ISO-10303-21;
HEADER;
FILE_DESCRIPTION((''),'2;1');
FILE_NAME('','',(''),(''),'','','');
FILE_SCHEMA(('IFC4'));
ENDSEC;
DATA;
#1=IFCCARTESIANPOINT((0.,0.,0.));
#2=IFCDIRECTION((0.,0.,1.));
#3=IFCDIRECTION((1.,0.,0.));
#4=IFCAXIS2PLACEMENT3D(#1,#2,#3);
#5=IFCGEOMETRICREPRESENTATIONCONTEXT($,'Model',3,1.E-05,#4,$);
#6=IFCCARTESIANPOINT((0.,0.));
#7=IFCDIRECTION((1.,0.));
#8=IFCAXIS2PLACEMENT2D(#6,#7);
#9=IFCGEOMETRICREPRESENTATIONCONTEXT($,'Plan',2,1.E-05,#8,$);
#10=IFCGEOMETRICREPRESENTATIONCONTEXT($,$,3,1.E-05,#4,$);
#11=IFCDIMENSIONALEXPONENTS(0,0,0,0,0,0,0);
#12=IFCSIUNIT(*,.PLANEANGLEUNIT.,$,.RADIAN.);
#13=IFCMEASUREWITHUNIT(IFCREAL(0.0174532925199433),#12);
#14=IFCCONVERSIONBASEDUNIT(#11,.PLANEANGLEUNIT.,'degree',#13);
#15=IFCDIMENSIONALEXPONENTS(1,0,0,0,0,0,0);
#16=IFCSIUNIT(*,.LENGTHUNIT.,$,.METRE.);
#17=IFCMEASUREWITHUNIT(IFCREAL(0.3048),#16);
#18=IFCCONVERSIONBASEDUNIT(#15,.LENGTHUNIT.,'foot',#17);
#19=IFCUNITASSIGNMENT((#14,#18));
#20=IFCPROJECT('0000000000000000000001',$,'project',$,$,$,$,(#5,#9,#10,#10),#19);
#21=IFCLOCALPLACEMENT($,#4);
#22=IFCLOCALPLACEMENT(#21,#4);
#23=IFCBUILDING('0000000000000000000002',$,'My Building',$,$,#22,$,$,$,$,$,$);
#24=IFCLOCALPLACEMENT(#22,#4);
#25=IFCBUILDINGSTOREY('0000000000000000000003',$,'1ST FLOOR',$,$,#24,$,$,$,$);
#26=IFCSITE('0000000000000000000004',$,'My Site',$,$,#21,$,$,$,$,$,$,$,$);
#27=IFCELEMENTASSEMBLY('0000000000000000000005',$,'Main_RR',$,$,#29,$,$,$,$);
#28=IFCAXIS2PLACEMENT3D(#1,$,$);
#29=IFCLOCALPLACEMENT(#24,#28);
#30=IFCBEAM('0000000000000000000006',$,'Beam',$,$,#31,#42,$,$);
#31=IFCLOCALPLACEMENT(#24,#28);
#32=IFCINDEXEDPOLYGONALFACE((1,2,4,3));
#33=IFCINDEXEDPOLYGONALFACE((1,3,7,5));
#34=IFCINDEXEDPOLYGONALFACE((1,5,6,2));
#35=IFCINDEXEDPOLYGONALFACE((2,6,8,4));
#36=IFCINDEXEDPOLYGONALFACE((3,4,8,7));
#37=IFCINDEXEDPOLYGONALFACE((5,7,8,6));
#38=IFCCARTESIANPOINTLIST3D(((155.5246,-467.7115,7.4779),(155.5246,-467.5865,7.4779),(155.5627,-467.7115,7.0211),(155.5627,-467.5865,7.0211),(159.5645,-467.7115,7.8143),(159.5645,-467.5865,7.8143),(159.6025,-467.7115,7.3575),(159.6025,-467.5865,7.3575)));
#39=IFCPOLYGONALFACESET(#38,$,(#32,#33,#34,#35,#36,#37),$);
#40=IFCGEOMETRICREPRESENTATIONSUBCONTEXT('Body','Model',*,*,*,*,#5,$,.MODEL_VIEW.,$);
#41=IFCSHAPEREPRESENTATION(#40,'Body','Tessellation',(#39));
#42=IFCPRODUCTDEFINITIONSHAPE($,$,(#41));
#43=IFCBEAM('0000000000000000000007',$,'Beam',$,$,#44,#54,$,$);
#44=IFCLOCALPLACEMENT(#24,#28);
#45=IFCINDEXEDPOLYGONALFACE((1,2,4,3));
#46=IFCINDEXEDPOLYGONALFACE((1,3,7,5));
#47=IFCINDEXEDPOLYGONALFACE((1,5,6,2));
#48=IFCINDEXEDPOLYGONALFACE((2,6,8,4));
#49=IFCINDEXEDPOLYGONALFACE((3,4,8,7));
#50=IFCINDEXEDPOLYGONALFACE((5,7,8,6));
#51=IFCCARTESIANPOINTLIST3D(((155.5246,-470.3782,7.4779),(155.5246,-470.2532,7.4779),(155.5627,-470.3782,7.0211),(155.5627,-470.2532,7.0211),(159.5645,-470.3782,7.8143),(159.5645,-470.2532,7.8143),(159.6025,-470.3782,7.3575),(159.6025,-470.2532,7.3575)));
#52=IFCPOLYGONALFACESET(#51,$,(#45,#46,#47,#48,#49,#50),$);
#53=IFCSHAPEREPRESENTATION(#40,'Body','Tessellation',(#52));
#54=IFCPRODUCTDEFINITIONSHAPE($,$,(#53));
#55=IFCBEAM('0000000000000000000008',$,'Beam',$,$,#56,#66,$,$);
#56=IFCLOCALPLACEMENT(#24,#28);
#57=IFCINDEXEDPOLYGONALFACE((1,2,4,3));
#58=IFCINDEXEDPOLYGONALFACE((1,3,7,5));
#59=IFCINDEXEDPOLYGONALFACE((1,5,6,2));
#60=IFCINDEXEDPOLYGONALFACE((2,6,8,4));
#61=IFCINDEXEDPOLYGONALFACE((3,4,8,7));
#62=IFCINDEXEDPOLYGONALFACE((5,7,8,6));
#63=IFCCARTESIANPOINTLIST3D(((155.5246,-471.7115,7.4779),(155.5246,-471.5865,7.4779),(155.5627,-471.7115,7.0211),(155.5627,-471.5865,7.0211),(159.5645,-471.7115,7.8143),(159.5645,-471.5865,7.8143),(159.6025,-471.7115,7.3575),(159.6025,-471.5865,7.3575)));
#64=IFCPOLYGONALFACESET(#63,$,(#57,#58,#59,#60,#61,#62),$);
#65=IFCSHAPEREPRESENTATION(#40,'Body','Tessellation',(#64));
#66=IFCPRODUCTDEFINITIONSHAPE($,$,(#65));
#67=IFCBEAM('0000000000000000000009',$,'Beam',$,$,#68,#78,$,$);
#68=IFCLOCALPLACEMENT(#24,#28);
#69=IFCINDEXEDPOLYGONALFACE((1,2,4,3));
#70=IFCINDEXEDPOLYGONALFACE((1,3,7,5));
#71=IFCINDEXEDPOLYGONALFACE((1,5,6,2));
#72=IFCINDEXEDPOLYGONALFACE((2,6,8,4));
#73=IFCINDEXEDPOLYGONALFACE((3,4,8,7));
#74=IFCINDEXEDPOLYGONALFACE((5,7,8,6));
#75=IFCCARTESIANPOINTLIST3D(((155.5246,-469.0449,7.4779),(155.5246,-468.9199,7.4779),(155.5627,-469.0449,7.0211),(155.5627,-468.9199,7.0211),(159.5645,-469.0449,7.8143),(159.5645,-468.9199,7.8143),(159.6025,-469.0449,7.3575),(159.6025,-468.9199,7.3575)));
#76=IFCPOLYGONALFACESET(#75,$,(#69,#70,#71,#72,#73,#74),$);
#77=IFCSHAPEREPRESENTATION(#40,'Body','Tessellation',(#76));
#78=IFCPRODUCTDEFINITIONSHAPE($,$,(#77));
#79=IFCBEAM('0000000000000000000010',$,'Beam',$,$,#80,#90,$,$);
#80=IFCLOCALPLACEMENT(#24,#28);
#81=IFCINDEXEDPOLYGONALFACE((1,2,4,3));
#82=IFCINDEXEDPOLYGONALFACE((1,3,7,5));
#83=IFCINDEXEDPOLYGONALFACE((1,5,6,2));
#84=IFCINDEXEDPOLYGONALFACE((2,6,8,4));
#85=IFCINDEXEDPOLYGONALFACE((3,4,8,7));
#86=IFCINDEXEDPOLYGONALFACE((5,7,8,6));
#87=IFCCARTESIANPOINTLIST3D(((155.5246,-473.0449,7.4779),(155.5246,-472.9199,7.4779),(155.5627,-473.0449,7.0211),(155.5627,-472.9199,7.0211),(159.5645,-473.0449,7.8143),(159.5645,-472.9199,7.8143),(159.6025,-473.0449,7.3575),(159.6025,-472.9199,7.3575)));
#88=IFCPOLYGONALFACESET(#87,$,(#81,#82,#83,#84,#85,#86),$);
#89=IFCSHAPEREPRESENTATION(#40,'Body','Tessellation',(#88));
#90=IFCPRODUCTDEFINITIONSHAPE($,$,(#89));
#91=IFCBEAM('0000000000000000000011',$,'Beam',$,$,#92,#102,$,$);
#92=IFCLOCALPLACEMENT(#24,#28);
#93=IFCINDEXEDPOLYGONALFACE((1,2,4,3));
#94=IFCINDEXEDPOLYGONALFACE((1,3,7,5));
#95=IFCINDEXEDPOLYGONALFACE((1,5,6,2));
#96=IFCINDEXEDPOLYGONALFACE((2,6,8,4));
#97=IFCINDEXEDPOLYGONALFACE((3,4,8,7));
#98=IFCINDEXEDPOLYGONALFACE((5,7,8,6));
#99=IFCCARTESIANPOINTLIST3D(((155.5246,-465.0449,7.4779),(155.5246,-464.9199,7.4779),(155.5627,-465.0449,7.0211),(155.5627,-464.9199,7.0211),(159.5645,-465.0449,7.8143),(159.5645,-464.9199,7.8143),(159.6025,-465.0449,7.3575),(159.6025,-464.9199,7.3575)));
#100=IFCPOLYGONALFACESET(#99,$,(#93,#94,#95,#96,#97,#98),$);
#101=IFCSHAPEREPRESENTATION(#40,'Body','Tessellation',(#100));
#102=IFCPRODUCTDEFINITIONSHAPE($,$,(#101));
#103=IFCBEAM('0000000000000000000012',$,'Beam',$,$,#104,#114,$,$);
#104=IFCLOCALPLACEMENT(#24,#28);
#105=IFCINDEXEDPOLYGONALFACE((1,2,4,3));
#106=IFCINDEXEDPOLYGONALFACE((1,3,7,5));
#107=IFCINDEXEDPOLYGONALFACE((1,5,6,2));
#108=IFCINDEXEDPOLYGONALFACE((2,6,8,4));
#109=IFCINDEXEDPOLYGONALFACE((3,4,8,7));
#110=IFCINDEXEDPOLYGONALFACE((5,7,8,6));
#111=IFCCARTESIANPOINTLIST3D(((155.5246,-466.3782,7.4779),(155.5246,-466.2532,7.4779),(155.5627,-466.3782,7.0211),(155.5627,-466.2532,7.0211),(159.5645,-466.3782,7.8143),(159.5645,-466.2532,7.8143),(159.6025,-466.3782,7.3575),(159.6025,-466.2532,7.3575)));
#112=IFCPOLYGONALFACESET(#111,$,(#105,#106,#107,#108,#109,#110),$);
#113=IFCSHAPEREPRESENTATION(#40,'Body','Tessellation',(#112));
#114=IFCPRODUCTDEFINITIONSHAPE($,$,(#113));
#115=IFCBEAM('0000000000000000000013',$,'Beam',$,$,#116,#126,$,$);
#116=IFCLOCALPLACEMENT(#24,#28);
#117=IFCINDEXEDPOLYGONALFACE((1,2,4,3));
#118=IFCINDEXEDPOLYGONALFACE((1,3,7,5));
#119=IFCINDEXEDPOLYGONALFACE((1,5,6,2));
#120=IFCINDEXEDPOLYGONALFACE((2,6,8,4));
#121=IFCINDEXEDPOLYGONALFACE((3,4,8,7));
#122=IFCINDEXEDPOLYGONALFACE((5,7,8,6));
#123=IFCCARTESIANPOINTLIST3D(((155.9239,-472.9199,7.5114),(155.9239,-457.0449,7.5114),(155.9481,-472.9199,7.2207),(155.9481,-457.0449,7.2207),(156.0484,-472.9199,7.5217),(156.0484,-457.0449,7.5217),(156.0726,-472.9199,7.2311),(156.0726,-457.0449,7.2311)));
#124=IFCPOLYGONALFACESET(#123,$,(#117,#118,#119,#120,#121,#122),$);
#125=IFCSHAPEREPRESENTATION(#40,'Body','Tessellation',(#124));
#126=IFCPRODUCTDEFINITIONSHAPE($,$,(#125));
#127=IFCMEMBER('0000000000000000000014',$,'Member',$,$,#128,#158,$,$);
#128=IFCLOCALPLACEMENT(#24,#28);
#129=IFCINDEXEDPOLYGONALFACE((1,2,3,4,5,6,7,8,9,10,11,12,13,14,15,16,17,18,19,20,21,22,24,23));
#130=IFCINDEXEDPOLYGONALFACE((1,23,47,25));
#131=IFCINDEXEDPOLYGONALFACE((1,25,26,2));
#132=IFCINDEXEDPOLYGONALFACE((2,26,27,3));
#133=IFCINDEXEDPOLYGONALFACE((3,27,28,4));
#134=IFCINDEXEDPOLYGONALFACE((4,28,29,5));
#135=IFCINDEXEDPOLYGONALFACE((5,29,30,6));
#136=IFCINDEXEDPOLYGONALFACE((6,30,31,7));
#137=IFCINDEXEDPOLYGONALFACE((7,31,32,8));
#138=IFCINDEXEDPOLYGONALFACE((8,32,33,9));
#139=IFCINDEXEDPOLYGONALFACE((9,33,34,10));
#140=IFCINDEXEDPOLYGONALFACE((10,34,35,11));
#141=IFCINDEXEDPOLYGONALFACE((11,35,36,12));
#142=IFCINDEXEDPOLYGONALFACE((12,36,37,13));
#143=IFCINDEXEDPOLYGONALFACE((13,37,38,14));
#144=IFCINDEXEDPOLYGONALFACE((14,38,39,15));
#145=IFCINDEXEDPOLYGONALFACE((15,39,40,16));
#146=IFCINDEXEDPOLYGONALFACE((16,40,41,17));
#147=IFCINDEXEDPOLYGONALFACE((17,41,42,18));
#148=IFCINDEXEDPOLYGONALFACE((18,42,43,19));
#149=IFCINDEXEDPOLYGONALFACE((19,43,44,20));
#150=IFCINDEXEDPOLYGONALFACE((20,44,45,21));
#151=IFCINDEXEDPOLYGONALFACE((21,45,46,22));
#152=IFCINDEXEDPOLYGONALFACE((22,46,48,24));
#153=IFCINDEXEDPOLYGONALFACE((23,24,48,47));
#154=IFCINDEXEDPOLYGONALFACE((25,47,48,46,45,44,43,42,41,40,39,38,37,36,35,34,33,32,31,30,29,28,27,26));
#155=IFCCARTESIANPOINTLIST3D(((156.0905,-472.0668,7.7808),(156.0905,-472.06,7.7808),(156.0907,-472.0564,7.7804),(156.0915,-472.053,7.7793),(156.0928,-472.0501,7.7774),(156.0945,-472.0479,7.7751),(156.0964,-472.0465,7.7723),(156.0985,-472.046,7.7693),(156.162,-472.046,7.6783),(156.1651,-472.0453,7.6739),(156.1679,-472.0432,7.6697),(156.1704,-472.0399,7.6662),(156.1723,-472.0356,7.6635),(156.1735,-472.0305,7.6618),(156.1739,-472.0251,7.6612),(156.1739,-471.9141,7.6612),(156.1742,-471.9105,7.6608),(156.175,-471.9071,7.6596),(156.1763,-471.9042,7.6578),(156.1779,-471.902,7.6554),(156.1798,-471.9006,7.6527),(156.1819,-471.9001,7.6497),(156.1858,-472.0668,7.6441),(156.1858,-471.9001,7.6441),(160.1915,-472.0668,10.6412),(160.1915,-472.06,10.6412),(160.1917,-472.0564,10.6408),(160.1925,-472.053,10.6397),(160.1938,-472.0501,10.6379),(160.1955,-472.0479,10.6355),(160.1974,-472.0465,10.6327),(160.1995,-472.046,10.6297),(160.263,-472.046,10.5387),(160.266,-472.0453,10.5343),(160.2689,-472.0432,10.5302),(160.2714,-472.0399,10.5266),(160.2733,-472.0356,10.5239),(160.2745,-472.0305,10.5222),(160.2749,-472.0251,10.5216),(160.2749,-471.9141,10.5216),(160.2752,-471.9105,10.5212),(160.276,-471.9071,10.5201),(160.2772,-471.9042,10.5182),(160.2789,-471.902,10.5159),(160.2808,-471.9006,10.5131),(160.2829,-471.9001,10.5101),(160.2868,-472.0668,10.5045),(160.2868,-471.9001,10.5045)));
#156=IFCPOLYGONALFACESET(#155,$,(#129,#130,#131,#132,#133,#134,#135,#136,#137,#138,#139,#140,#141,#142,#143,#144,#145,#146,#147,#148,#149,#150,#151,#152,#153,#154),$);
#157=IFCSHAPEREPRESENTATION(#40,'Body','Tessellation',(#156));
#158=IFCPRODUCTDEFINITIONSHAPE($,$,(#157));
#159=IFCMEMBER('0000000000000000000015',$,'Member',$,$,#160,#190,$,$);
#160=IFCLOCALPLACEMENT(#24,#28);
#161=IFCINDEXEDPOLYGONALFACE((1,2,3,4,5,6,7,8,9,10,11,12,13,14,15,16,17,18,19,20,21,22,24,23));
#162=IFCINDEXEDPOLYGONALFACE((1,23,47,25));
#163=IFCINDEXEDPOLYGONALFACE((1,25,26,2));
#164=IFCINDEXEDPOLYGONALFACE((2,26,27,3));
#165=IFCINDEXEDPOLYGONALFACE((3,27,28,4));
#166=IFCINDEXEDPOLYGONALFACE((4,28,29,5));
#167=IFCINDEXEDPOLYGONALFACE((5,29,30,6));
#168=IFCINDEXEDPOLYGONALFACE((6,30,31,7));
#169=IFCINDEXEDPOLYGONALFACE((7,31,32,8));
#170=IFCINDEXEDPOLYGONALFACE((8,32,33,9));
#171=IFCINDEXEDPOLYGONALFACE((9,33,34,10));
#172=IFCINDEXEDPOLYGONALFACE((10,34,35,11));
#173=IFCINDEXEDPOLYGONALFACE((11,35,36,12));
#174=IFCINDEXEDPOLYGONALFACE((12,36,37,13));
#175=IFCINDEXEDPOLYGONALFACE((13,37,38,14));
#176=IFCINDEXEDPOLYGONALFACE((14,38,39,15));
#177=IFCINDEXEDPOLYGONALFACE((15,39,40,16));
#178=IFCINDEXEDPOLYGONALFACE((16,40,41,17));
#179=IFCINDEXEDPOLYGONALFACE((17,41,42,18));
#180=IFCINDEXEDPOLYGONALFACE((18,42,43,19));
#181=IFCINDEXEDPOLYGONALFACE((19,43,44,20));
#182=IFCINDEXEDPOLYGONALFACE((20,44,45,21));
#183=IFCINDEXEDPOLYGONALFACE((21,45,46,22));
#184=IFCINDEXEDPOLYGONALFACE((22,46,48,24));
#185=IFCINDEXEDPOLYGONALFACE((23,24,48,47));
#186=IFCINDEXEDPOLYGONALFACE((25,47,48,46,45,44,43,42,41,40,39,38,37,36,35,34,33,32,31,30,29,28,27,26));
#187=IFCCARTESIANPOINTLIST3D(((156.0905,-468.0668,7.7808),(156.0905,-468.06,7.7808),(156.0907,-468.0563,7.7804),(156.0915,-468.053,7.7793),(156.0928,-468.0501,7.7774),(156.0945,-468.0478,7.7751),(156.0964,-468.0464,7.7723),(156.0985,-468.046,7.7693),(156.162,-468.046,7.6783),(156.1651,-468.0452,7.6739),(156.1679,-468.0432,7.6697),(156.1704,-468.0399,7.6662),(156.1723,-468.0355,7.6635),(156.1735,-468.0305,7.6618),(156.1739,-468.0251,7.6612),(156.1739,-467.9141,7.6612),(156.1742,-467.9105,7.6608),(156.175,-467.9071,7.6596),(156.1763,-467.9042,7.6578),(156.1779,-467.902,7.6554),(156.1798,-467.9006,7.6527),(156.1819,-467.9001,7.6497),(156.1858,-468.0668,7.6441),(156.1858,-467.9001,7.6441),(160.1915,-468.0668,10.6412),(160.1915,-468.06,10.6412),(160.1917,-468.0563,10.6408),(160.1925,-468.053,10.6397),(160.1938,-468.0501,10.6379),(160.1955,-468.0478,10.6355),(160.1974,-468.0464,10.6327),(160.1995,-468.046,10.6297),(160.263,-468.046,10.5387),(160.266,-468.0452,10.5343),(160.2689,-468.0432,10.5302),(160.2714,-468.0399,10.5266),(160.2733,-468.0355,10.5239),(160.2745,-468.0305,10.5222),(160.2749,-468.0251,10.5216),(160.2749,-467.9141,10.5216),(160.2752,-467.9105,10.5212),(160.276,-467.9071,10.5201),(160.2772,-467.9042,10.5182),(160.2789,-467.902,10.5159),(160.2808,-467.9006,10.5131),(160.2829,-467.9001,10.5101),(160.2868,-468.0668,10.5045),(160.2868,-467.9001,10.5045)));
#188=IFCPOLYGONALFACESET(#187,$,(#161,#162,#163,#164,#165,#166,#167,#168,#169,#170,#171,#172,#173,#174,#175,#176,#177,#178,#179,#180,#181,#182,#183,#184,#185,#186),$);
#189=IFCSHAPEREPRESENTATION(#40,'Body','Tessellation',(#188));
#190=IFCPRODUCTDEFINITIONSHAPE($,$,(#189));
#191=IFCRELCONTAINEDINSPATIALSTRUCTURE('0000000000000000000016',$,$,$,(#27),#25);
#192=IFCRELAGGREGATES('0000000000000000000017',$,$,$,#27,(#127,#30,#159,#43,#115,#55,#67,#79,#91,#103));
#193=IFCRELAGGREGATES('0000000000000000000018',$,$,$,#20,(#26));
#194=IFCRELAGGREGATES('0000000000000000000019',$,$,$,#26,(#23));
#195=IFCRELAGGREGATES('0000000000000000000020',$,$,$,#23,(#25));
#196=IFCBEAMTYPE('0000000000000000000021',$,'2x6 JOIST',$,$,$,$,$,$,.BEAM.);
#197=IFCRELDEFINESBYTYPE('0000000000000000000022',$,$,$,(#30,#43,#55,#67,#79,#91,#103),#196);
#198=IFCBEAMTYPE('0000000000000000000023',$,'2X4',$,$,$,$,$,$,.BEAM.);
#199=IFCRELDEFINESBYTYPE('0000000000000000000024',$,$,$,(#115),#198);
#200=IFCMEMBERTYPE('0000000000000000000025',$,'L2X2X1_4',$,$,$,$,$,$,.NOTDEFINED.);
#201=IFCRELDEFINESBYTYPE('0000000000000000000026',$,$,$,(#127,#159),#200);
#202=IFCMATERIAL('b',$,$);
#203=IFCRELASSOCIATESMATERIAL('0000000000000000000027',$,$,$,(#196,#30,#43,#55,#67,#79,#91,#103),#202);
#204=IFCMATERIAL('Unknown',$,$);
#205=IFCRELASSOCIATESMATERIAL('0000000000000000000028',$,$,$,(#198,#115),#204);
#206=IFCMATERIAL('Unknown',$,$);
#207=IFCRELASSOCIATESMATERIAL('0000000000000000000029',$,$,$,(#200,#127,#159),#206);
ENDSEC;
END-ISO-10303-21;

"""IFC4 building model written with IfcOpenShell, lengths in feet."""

from ifc_helpers import new_model, entity, si_unit, converted_unit, frame, origin_with_axes, origin_2d_with_axis, place, context, subcontext, project, spatial, rectangle, l_section, extrude, material, material_profile, profile_set, profile_usage, type_object, element, aggregate, save


model = new_model("IFC4")

# Units and contexts
model_context = context("Model", 3, precision=1e-05, world=origin_with_axes())
plan_context = context("Plan", 2, precision=1e-05, world=origin_2d_with_axis())
context_of_model = context(None, 3, precision=1e-05, world=origin_with_axes())
body_context_1 = subcontext(model_context, "Body", "Model", "MODEL_VIEW")
ifc_project = project(units=[converted_unit("PLANEANGLEUNIT", "degree", entity("IfcReal", 0.0174532925199433), si_unit("PLANEANGLEUNIT", "RADIAN"), dimensions=[0, 0, 0, 0, 0, 0, 0]), converted_unit("LENGTHUNIT", "foot", entity("IfcReal", 0.3048), si_unit("LENGTHUNIT", "METRE"), dimensions=[1, 0, 0, 0, 0, 0, 0])], contexts=[model_context, plan_context, context_of_model, context_of_model])

# Site, building, storey
site_placement = place(None, origin_with_axes())
site = spatial("IfcSite", under=ifc_project, at=site_placement, Name="My Site")
building_placement = place(site_placement, origin_with_axes())
building = spatial("IfcBuilding", under=site, at=building_placement, Name="My Building")
storey_placement = place(building_placement, origin_with_axes())
storey = spatial("IfcBuildingStorey", under=building, at=storey_placement, Name="1ST FLOOR")

# Element assembly, beams, members
assembly_1_placement = place(storey_placement, origin_with_axes())
assembly_1 = element("IfcElementAssembly", 1, at=assembly_1_placement, inside=storey, Name="Main_RR")
ifc_material_1 = material(Name="b")
ifc_material_profile_1 = material_profile(ifc_material_1, rectangle(XDim=0.125, YDim=0.4583))
ifc_profile_set_1 = profile_set([ifc_material_profile_1])
ifc_profile_usage_1 = profile_usage(ifc_profile_set_1)
beam_type_1 = type_object("IfcBeamType", Name="2x6 JOIST", PredefinedType="BEAM", material=ifc_profile_set_1)
beam_1_placement = place(assembly_1_placement, frame((159.5835, -467.649, 7.5859), z_axis=(-0.996551, 0.0, -0.082982), x_axis=(0.0, -1.0, 0.0)))
beam_1 = element("IfcBeam", 2, at=beam_1_placement, type_object=beam_type_1, material=ifc_profile_usage_1, Name="Beam", context=body_context_1, shape_type="SweptSolid", body=[
    extrude(rectangle(XDim=0.125, YDim=0.4583), origin_with_axes(), (0.0, 0.0, 1.0), 4.0539),
])
ifc_profile_usage_2 = profile_usage(ifc_profile_set_1)
beam_2_placement = place(assembly_1_placement, frame((159.5835, -470.3157, 7.5859), z_axis=(-0.996551, 0.0, -0.082982), x_axis=(0.0, -1.0, 0.0)))
beam_2 = element("IfcBeam", 3, at=beam_2_placement, type_object=beam_type_1, material=ifc_profile_usage_2, Name="Beam", context=body_context_1, shape_type="SweptSolid", body=[
    extrude(rectangle(XDim=0.125, YDim=0.4583), origin_with_axes(), (0.0, 0.0, 1.0), 4.0539),
])
ifc_profile_usage_3 = profile_usage(ifc_profile_set_1)
beam_3_placement = place(assembly_1_placement, frame((159.5835, -471.649, 7.5859), z_axis=(-0.996551, 0.0, -0.082982), x_axis=(0.0, -1.0, 0.0)))
beam_3 = element("IfcBeam", 4, at=beam_3_placement, type_object=beam_type_1, material=ifc_profile_usage_3, Name="Beam", context=body_context_1, shape_type="SweptSolid", body=[
    extrude(rectangle(XDim=0.125, YDim=0.4583), origin_with_axes(), (0.0, 0.0, 1.0), 4.0539),
])
ifc_profile_usage_4 = profile_usage(ifc_profile_set_1)
beam_4_placement = place(assembly_1_placement, frame((159.5835, -468.9824, 7.5859), z_axis=(-0.996551, 0.0, -0.082982), x_axis=(0.0, -1.0, 0.0)))
beam_4 = element("IfcBeam", 5, at=beam_4_placement, type_object=beam_type_1, material=ifc_profile_usage_4, Name="Beam", context=body_context_1, shape_type="SweptSolid", body=[
    extrude(rectangle(XDim=0.125, YDim=0.4583), origin_with_axes(), (0.0, 0.0, 1.0), 4.0539),
])
ifc_profile_usage_5 = profile_usage(ifc_profile_set_1)
beam_5_placement = place(assembly_1_placement, frame((159.5835, -472.9824, 7.5859), z_axis=(-0.996551, 0.0, -0.082982), x_axis=(0.0, -1.0, 0.0)))
beam_5 = element("IfcBeam", 6, at=beam_5_placement, type_object=beam_type_1, material=ifc_profile_usage_5, Name="Beam", context=body_context_1, shape_type="SweptSolid", body=[
    extrude(rectangle(XDim=0.125, YDim=0.4583), origin_with_axes(), (0.0, 0.0, 1.0), 4.0539),
])
ifc_profile_usage_6 = profile_usage(ifc_profile_set_1)
beam_6_placement = place(assembly_1_placement, frame((159.5835, -464.9824, 7.5859), z_axis=(-0.996551, 0.0, -0.082982), x_axis=(0.0, -1.0, 0.0)))
beam_6 = element("IfcBeam", 7, at=beam_6_placement, type_object=beam_type_1, material=ifc_profile_usage_6, Name="Beam", context=body_context_1, shape_type="SweptSolid", body=[
    extrude(rectangle(XDim=0.125, YDim=0.4583), origin_with_axes(), (0.0, 0.0, 1.0), 4.0539),
])
ifc_profile_usage_7 = profile_usage(ifc_profile_set_1)
beam_7_placement = place(assembly_1_placement, frame((159.5835, -466.3157, 7.5859), z_axis=(-0.996551, 0.0, -0.082982), x_axis=(0.0, -1.0, 0.0)))
beam_7 = element("IfcBeam", 8, at=beam_7_placement, type_object=beam_type_1, material=ifc_profile_usage_7, Name="Beam", context=body_context_1, shape_type="SweptSolid", body=[
    extrude(rectangle(XDim=0.125, YDim=0.4583), origin_with_axes(), (0.0, 0.0, 1.0), 4.0539),
])
ifc_material_2 = material(Name="Unknown")
ifc_material_profile_2 = material_profile(ifc_material_2, rectangle(XDim=0.125, YDim=0.2917))
ifc_profile_set_2 = profile_set([ifc_material_profile_2])
ifc_profile_usage_8 = profile_usage(ifc_profile_set_2)
beam_type_2 = type_object("IfcBeamType", Name="2X4", PredefinedType="BEAM", material=ifc_profile_set_2)
beam_8_placement = place(assembly_1_placement, frame((155.9982, -472.9199, 7.3712), z_axis=(0.000001, 1.0, 0.0), x_axis=(-0.996551, 0.000001, -0.082982)))
beam_8 = element("IfcBeam", 9, at=beam_8_placement, type_object=beam_type_2, material=ifc_profile_usage_8, Name="Beam", context=body_context_1, shape_type="SweptSolid", body=[
    extrude(rectangle(XDim=0.125, YDim=0.2917), origin_with_axes(), (0.0, 0.0, 1.0), 15.875),
])
ifc_material_3 = material(Name="Unknown")
ifc_material_profile_3 = material_profile(ifc_material_3, l_section(Depth=0.1667, Width=0.1667, Thickness=0.0208, FilletRadius=0.0208, EdgeRadius=0.014))
ifc_profile_set_3 = profile_set([ifc_material_profile_3])
ifc_profile_usage_9 = profile_usage(ifc_profile_set_3, cardinal=5)
member_type = type_object("IfcMemberType", Name="L2X2X1_4", PredefinedType="NOTDEFINED", material=ifc_profile_set_3)
member_1_placement = place(assembly_1_placement, frame((156.1381, -471.9835, 7.7124), z_axis=(0.820194, 0.0, 0.572085), x_axis=(0.0, 1.0, 0.0)))
member_1 = element("IfcMember", 10, at=member_1_placement, type_object=member_type, material=ifc_profile_usage_9, Name="Member", context=body_context_1, shape_type="SweptSolid", body=[
    extrude(l_section(Depth=0.1667, Width=0.1667, Thickness=0.0208, FilletRadius=0.0208, EdgeRadius=0.014), origin_with_axes(), (0.0, 0.0, 1.0), 5.0),
])
ifc_profile_usage_10 = profile_usage(ifc_profile_set_3, cardinal=5)
member_2_placement = place(assembly_1_placement, frame((156.1381, -467.9835, 7.7124), z_axis=(0.820194, 0.0, 0.572085), x_axis=(0.0, 1.0, 0.0)))
member_2 = element("IfcMember", 11, at=member_2_placement, type_object=member_type, material=ifc_profile_usage_10, Name="Member", context=body_context_1, shape_type="SweptSolid", body=[
    extrude(l_section(Depth=0.1667, Width=0.1667, Thickness=0.0208, FilletRadius=0.0208, EdgeRadius=0.014), origin_with_axes(), (0.0, 0.0, 1.0), 5.0),
])

aggregate(assembly_1, [member_1, beam_1, member_2, beam_2, beam_8, beam_3, beam_4, beam_5, beam_6, beam_7])

save(model, "model.ifc")
